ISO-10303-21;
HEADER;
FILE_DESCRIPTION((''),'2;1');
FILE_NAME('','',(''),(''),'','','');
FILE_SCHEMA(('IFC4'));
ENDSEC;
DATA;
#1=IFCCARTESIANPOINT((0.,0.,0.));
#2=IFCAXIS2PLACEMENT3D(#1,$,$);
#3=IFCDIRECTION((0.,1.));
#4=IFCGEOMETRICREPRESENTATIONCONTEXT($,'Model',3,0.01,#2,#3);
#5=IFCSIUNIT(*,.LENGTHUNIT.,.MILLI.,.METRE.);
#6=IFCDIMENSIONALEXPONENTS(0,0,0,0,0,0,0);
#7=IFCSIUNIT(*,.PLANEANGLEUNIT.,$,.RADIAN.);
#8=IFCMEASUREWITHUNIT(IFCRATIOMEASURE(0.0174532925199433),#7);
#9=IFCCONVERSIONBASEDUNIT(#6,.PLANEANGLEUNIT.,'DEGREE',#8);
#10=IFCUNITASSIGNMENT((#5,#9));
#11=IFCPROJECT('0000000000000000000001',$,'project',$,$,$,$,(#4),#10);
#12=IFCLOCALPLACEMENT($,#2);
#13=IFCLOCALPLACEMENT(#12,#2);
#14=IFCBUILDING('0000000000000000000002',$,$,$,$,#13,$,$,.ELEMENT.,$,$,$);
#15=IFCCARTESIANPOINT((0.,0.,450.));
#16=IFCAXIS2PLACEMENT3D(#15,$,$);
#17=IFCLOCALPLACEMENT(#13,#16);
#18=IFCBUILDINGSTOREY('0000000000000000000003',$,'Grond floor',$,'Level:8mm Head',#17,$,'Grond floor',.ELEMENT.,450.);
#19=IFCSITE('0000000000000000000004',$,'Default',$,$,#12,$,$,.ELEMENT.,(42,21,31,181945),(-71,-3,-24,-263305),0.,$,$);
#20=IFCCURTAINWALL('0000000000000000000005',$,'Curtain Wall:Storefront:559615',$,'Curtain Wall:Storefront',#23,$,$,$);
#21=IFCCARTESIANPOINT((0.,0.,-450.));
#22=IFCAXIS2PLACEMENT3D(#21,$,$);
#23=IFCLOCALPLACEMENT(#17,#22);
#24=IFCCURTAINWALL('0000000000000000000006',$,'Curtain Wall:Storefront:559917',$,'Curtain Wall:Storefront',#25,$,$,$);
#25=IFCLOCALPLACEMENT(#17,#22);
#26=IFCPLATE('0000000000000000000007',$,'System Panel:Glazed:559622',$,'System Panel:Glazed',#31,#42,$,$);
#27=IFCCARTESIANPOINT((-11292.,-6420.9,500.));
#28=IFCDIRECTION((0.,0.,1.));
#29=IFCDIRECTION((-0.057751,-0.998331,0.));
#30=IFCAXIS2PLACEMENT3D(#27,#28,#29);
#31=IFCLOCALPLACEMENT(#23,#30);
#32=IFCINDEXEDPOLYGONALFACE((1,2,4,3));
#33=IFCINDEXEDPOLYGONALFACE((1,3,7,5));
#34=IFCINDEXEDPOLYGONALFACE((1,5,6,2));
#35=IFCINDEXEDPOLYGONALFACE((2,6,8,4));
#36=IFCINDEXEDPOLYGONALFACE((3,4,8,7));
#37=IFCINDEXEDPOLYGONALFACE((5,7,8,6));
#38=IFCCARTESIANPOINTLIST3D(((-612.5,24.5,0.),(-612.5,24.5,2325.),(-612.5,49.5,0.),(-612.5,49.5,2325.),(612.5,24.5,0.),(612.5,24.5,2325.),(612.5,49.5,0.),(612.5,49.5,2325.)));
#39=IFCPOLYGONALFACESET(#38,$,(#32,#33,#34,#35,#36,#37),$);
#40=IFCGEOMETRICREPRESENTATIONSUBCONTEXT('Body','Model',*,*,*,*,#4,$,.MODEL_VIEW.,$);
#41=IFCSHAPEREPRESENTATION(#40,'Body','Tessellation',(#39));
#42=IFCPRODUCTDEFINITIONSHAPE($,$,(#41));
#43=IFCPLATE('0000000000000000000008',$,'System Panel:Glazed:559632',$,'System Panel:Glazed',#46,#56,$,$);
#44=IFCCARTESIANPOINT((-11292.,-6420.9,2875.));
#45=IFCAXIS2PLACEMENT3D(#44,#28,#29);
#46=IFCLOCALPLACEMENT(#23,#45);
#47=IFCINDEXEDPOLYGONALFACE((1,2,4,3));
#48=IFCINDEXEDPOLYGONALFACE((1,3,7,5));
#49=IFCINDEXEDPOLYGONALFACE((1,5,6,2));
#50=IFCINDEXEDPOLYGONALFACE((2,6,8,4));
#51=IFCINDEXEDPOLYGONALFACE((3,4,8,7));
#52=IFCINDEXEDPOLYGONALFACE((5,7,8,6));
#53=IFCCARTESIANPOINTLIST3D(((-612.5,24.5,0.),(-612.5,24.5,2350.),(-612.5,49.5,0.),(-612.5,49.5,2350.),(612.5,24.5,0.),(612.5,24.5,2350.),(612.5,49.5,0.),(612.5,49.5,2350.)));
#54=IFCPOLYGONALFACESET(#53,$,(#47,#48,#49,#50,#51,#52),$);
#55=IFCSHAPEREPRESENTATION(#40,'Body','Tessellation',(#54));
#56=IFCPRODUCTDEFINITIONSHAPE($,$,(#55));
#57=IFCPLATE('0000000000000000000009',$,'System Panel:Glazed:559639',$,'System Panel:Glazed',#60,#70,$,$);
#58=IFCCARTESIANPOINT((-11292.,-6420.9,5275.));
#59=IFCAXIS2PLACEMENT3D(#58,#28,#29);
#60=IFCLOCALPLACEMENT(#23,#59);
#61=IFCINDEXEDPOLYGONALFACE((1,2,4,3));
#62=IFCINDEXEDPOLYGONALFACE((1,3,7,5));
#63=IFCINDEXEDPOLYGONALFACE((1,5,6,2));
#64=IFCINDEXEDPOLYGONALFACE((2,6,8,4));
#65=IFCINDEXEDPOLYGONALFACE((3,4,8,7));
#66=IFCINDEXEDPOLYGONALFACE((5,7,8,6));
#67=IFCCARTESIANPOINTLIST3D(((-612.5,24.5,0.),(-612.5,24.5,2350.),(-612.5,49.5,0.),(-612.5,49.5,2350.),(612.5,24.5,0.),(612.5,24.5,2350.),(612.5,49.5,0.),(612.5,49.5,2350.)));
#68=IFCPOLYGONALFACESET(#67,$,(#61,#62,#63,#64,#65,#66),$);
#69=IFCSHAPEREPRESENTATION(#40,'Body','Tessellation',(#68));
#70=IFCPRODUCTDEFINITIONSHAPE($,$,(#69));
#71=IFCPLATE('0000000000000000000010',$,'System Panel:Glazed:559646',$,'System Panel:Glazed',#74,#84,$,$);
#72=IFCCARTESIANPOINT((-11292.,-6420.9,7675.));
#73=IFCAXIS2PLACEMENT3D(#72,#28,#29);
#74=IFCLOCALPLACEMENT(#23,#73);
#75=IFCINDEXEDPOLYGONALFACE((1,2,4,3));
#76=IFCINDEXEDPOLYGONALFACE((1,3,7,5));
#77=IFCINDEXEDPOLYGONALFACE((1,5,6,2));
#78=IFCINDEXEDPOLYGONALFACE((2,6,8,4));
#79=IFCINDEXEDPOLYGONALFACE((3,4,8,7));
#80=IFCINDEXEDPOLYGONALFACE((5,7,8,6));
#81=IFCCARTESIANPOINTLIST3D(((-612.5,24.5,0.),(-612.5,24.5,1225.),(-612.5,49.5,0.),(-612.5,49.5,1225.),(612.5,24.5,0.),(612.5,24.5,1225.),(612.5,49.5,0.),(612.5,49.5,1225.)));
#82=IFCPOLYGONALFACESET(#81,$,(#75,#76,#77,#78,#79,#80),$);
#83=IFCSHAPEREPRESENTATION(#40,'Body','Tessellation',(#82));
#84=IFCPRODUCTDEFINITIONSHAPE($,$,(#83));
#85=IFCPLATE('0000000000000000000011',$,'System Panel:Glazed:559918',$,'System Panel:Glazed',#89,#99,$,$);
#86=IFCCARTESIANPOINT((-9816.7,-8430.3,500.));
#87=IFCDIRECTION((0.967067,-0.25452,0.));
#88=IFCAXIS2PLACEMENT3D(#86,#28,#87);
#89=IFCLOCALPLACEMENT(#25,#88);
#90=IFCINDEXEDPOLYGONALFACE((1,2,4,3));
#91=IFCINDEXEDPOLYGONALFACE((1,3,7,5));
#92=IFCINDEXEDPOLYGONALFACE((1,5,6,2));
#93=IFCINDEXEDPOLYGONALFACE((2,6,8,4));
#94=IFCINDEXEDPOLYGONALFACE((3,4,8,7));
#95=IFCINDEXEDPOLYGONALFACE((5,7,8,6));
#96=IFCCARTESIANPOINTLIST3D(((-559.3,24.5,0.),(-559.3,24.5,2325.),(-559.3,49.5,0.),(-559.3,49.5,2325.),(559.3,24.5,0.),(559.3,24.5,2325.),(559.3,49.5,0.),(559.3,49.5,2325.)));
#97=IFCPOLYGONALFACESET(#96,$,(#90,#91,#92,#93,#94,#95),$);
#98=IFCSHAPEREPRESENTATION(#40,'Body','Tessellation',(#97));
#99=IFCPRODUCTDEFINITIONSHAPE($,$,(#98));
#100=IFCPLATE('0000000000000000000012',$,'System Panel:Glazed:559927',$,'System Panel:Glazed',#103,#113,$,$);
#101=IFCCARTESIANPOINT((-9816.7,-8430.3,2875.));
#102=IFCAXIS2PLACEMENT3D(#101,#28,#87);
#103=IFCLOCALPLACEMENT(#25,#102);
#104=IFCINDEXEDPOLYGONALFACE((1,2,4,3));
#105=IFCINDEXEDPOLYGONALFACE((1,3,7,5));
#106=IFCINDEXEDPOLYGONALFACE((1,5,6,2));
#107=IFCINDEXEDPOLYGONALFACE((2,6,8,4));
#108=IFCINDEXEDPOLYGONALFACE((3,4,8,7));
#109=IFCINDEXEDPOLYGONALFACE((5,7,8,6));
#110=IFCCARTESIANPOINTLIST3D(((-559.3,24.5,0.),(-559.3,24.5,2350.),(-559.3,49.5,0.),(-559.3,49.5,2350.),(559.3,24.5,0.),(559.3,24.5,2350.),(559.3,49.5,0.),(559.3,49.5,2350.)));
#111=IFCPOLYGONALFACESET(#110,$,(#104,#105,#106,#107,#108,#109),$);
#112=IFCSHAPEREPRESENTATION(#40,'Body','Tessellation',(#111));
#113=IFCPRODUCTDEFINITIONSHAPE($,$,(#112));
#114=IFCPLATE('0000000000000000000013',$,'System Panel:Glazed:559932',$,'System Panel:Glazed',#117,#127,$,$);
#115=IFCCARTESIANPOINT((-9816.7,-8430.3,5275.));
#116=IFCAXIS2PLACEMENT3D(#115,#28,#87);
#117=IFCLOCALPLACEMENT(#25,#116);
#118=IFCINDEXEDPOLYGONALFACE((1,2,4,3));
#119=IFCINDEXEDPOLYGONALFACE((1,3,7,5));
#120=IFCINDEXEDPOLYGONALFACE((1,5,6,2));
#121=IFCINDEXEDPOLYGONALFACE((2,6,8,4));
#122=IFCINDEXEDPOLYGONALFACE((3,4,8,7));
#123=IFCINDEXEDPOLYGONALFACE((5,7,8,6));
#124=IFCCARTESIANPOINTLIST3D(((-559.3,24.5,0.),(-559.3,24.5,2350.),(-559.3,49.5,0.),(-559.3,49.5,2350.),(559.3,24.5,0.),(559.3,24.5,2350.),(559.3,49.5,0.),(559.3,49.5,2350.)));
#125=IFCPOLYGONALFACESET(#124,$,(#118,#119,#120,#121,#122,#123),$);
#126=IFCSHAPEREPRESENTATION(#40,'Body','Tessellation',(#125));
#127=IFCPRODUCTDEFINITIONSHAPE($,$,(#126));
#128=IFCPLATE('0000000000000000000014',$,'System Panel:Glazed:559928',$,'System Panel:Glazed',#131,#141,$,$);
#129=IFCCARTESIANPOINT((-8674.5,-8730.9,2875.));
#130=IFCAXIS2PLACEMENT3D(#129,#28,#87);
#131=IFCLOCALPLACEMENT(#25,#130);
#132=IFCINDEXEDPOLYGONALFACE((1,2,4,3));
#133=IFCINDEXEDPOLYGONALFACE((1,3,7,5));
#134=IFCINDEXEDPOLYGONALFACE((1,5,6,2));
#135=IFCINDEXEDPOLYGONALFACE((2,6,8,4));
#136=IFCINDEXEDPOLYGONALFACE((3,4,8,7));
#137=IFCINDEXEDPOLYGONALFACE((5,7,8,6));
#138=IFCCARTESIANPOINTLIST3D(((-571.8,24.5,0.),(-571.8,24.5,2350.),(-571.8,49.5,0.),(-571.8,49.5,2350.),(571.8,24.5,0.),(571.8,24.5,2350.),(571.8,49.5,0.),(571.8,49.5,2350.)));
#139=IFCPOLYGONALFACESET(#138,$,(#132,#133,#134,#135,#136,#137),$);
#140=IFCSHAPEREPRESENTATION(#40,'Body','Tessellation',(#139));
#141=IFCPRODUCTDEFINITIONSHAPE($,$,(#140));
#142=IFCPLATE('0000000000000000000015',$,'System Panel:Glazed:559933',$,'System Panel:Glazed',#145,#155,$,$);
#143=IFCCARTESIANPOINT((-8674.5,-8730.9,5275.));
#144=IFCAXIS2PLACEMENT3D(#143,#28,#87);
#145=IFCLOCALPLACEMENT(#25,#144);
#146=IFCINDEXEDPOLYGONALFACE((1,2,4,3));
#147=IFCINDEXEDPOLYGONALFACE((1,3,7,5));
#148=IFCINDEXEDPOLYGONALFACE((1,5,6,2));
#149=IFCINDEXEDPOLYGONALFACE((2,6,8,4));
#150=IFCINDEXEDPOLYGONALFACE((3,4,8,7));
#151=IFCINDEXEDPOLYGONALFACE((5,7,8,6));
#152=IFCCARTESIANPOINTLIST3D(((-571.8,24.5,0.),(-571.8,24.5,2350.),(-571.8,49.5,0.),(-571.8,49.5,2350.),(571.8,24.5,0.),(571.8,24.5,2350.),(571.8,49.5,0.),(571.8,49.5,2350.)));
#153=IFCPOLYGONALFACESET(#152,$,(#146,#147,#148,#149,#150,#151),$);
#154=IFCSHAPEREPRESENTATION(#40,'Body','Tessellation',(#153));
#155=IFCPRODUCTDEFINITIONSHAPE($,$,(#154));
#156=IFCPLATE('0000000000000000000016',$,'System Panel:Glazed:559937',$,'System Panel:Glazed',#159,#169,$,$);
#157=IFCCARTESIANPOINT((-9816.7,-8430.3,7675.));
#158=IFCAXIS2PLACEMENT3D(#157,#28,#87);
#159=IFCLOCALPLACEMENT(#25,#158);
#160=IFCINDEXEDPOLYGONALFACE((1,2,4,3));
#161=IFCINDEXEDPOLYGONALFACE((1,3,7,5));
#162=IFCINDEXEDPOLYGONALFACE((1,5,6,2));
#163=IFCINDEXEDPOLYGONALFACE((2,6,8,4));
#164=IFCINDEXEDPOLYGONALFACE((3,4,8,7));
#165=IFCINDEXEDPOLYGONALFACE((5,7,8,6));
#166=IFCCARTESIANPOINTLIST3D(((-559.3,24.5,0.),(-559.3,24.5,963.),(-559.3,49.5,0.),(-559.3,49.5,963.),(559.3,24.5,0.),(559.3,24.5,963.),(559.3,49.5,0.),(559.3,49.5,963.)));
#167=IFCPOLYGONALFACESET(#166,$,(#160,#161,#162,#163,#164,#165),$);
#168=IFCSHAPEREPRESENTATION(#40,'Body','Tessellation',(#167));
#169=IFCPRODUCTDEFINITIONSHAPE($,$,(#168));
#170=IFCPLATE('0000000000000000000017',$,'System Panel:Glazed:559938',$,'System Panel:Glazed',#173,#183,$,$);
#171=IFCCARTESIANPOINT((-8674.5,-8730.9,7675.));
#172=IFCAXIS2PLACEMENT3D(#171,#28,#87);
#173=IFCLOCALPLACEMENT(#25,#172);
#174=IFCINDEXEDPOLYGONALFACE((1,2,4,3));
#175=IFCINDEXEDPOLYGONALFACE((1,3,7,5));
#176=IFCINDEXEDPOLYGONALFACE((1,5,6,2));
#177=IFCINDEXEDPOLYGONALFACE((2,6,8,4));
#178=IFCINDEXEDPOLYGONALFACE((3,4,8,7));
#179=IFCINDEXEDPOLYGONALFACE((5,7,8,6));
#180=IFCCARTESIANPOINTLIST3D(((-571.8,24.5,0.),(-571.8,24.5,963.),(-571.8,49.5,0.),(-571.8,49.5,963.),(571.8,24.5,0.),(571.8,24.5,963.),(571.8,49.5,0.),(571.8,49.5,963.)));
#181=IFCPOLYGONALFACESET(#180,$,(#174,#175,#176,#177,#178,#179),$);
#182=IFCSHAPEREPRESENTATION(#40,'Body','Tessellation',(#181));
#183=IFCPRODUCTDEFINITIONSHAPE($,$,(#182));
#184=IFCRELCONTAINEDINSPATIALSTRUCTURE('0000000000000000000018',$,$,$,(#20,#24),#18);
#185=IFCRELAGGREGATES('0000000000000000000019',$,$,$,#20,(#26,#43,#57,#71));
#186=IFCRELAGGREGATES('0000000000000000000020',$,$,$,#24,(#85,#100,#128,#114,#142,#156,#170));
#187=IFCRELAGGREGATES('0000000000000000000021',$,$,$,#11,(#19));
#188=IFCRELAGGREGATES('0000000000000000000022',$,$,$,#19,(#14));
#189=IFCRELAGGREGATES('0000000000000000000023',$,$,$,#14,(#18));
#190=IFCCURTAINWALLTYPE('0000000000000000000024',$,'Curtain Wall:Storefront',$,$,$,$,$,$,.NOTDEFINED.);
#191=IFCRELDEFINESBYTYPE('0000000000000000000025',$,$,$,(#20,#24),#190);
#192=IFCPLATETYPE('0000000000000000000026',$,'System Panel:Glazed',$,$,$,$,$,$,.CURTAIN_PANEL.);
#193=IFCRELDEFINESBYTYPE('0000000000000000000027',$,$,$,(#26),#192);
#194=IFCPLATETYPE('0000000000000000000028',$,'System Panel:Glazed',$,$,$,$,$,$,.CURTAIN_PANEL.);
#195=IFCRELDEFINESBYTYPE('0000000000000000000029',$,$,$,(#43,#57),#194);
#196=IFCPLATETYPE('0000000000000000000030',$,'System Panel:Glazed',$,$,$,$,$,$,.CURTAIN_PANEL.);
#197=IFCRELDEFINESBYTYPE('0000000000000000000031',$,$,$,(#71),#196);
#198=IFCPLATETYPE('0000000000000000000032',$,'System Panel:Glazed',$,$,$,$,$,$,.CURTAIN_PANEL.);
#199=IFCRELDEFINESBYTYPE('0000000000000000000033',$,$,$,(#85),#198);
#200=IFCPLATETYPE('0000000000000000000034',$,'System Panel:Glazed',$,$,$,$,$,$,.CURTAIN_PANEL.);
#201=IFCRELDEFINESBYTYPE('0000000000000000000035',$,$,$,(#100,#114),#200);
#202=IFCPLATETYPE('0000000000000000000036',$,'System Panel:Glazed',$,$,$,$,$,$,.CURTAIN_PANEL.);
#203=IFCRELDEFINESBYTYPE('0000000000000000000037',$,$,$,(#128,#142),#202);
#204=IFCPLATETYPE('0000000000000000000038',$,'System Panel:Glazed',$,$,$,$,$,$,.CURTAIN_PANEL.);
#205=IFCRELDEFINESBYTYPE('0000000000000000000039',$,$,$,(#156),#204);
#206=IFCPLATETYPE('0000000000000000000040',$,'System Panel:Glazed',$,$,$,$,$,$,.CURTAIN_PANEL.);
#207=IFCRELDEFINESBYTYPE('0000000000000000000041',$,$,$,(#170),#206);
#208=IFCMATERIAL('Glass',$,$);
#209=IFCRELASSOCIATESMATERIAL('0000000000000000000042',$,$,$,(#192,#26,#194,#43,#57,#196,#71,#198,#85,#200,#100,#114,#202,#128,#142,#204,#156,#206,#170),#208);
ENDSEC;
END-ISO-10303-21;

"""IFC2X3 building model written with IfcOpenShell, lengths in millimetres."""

from ifc_helpers import new_model, entity, si_unit, converted_unit, direction, frame, frame_2d, origin, place, context, subcontext, project, spatial, rectangle, extrude, source, transform, mapped, material, type_object, type_shapes, element, aggregate, save


model = new_model("IFC2X3")

# Units and contexts
model_context = context("Model", 3, precision=0.01, world=origin(), true_north=direction((0.0, 1.0)))
body_context = subcontext(model_context, "Body", "Model", "MODEL_VIEW")
ifc_project = project(units=[si_unit("LENGTHUNIT", "METRE", prefix="MILLI"), converted_unit("PLANEANGLEUNIT", "DEGREE", entity("IfcRatioMeasure", 0.0174532925199433), si_unit("PLANEANGLEUNIT", "RADIAN"), dimensions=[0, 0, 0, 0, 0, 0, 0])], contexts=[model_context])

# Site, building, storey
site_placement = place(None, origin())
site = spatial("IfcSite", under=ifc_project, at=site_placement, Name="Default", CompositionType="ELEMENT", RefLatitude=(42, 21, 31, 181945), RefLongitude=(-71, -3, -24, -263305), RefElevation=0.0)
building_placement = place(site_placement, origin())
building = spatial("IfcBuilding", under=site, at=building_placement, CompositionType="ELEMENT")
storey_placement = place(building_placement, frame((0.0, 0.0, 450.0)))
storey = spatial("IfcBuildingStorey", under=building, at=storey_placement, Name="Grond floor", ObjectType="Level:8mm Head", LongName="Grond floor", CompositionType="ELEMENT", Elevation=450.0)

# Curtain walls
curtain_wall_type = type_object("IfcCurtainWallType", Name="Curtain Wall:Storefront", PredefinedType="NOTDEFINED")
curtain_wall_1_placement = place(storey_placement, frame((0.0, 0.0, -450.0)))
curtain_wall_1 = element("IfcCurtainWall", 1, at=curtain_wall_1_placement, inside=storey, type_object=curtain_wall_type, Name="Curtain Wall:Storefront:559615", ObjectType="Curtain Wall:Storefront")
curtain_wall_2_placement = place(storey_placement, frame((0.0, 0.0, -450.0)))
curtain_wall_2 = element("IfcCurtainWall", 2, at=curtain_wall_2_placement, inside=storey, type_object=curtain_wall_type, Name="Curtain Wall:Storefront:559917", ObjectType="Curtain Wall:Storefront")

# Plates
ifc_material_1 = material(Name="Glass")
plate_type_1 = type_object("IfcPlateType", Name="System Panel:Glazed", PredefinedType="CURTAIN_PANEL", material=ifc_material_1)
shared_shape_1 = source(origin(), body_context, "Body", "SweptSolid", [
    extrude(rectangle(XDim=25.0, YDim=1225.0, at=frame_2d((0.0, 0.0), x_axis=(1.0, 0.0))), frame((0.0, 37.0, 0.0), z_axis=(0.0, 0.0, 1.0), x_axis=(0.0, 1.0, 0.0)), (0.0, 0.0, 1.0), 2325.0),
])
type_shapes(plate_type_1, [shared_shape_1])
plate_1_placement = place(curtain_wall_1_placement, frame((-11292.0, -6420.9, 500.0), z_axis=(0.0, 0.0, 1.0), x_axis=(-0.057751, -0.998331, 0.0)))
plate_1 = element("IfcPlate", 3, at=plate_1_placement, type_object=plate_type_1, material=ifc_material_1, Name="System Panel:Glazed:559622", ObjectType="System Panel:Glazed", context=body_context, shape_type="MappedRepresentation", body=[
    mapped(shared_shape_1, transform((0.0, 0.0, 0.0), scale=1.0)),
])
plate_type_2 = type_object("IfcPlateType", Name="System Panel:Glazed", PredefinedType="CURTAIN_PANEL", material=ifc_material_1)
shared_shape_2 = source(origin(), body_context, "Body", "SweptSolid", [
    extrude(rectangle(XDim=25.0, YDim=1225.0, at=frame_2d((0.0, 0.0), x_axis=(1.0, 0.0))), frame((0.0, 37.0, 0.0), z_axis=(0.0, 0.0, 1.0), x_axis=(0.0, 1.0, 0.0)), (0.0, 0.0, 1.0), 2350.0),
])
type_shapes(plate_type_2, [shared_shape_2])
plate_2_placement = place(curtain_wall_1_placement, frame((-11292.0, -6420.9, 2875.0), z_axis=(0.0, 0.0, 1.0), x_axis=(-0.057751, -0.998331, 0.0)))
plate_2 = element("IfcPlate", 4, at=plate_2_placement, type_object=plate_type_2, material=ifc_material_1, Name="System Panel:Glazed:559632", ObjectType="System Panel:Glazed", context=body_context, shape_type="MappedRepresentation", body=[
    mapped(shared_shape_2, transform((0.0, 0.0, 0.0), scale=1.0)),
])
plate_3_placement = place(curtain_wall_1_placement, frame((-11292.0, -6420.9, 5275.0), z_axis=(0.0, 0.0, 1.0), x_axis=(-0.057751, -0.998331, 0.0)))
plate_3 = element("IfcPlate", 5, at=plate_3_placement, type_object=plate_type_2, material=ifc_material_1, Name="System Panel:Glazed:559639", ObjectType="System Panel:Glazed", context=body_context, shape_type="MappedRepresentation", body=[
    mapped(shared_shape_2, transform((0.0, 0.0, 0.0), scale=1.0)),
])
plate_type_3 = type_object("IfcPlateType", Name="System Panel:Glazed", PredefinedType="CURTAIN_PANEL", material=ifc_material_1)
shared_shape_3 = source(origin(), body_context, "Body", "SweptSolid", [
    extrude(rectangle(XDim=25.0, YDim=1225.0, at=frame_2d((0.0, 0.0), x_axis=(1.0, 0.0))), frame((0.0, 37.0, 0.0), z_axis=(0.0, 0.0, 1.0), x_axis=(0.0, 1.0, 0.0)), (0.0, 0.0, 1.0), 1225.0),
])
type_shapes(plate_type_3, [shared_shape_3])
plate_4_placement = place(curtain_wall_1_placement, frame((-11292.0, -6420.9, 7675.0), z_axis=(0.0, 0.0, 1.0), x_axis=(-0.057751, -0.998331, 0.0)))
plate_4 = element("IfcPlate", 6, at=plate_4_placement, type_object=plate_type_3, material=ifc_material_1, Name="System Panel:Glazed:559646", ObjectType="System Panel:Glazed", context=body_context, shape_type="MappedRepresentation", body=[
    mapped(shared_shape_3, transform((0.0, 0.0, 0.0), scale=1.0)),
])
aggregate(curtain_wall_1, [plate_1, plate_2, plate_3, plate_4])
plate_type_4 = type_object("IfcPlateType", Name="System Panel:Glazed", PredefinedType="CURTAIN_PANEL", material=ifc_material_1)
shared_shape_4 = source(origin(), body_context, "Body", "SweptSolid", [
    extrude(rectangle(XDim=25.0, YDim=1118.6, at=frame_2d((0.0, 0.0), x_axis=(1.0, 0.0))), frame((0.0, 37.0, 0.0), z_axis=(0.0, 0.0, 1.0), x_axis=(0.0, 1.0, 0.0)), (0.0, 0.0, 1.0), 2325.0),
])
type_shapes(plate_type_4, [shared_shape_4])
plate_5_placement = place(curtain_wall_2_placement, frame((-9816.7, -8430.3, 500.0), z_axis=(0.0, 0.0, 1.0), x_axis=(0.967067, -0.25452, 0.0)))
plate_5 = element("IfcPlate", 7, at=plate_5_placement, type_object=plate_type_4, material=ifc_material_1, Name="System Panel:Glazed:559918", ObjectType="System Panel:Glazed", context=body_context, shape_type="MappedRepresentation", body=[
    mapped(shared_shape_4, transform((0.0, 0.0, 0.0), scale=1.0)),
])
plate_type_5 = type_object("IfcPlateType", Name="System Panel:Glazed", PredefinedType="CURTAIN_PANEL", material=ifc_material_1)
shared_shape_5 = source(origin(), body_context, "Body", "SweptSolid", [
    extrude(rectangle(XDim=25.0, YDim=1118.6, at=frame_2d((0.0, 0.0), x_axis=(1.0, 0.0))), frame((0.0, 37.0, 0.0), z_axis=(0.0, 0.0, 1.0), x_axis=(0.0, 1.0, 0.0)), (0.0, 0.0, 1.0), 2350.0),
])
type_shapes(plate_type_5, [shared_shape_5])
plate_6_placement = place(curtain_wall_2_placement, frame((-9816.7, -8430.3, 2875.0), z_axis=(0.0, 0.0, 1.0), x_axis=(0.967067, -0.25452, 0.0)))
plate_6 = element("IfcPlate", 8, at=plate_6_placement, type_object=plate_type_5, material=ifc_material_1, Name="System Panel:Glazed:559927", ObjectType="System Panel:Glazed", context=body_context, shape_type="MappedRepresentation", body=[
    mapped(shared_shape_5, transform((0.0, 0.0, 0.0), scale=1.0)),
])
plate_7_placement = place(curtain_wall_2_placement, frame((-9816.7, -8430.3, 5275.0), z_axis=(0.0, 0.0, 1.0), x_axis=(0.967067, -0.25452, 0.0)))
plate_7 = element("IfcPlate", 9, at=plate_7_placement, type_object=plate_type_5, material=ifc_material_1, Name="System Panel:Glazed:559932", ObjectType="System Panel:Glazed", context=body_context, shape_type="MappedRepresentation", body=[
    mapped(shared_shape_5, transform((0.0, 0.0, 0.0), scale=1.0)),
])
plate_type_6 = type_object("IfcPlateType", Name="System Panel:Glazed", PredefinedType="CURTAIN_PANEL", material=ifc_material_1)
shared_shape_6 = source(origin(), body_context, "Body", "SweptSolid", [
    extrude(rectangle(XDim=25.0, YDim=1143.6, at=frame_2d((0.0, 0.0), x_axis=(1.0, 0.0))), frame((0.0, 37.0, 0.0), z_axis=(0.0, 0.0, 1.0), x_axis=(0.0, 1.0, 0.0)), (0.0, 0.0, 1.0), 2350.0),
])
type_shapes(plate_type_6, [shared_shape_6])
plate_8_placement = place(curtain_wall_2_placement, frame((-8674.5, -8730.9, 2875.0), z_axis=(0.0, 0.0, 1.0), x_axis=(0.967067, -0.25452, 0.0)))
plate_8 = element("IfcPlate", 10, at=plate_8_placement, type_object=plate_type_6, material=ifc_material_1, Name="System Panel:Glazed:559928", ObjectType="System Panel:Glazed", context=body_context, shape_type="MappedRepresentation", body=[
    mapped(shared_shape_6, transform((0.0, 0.0, 0.0), scale=1.0)),
])
plate_9_placement = place(curtain_wall_2_placement, frame((-8674.5, -8730.9, 5275.0), z_axis=(0.0, 0.0, 1.0), x_axis=(0.967067, -0.25452, 0.0)))
plate_9 = element("IfcPlate", 11, at=plate_9_placement, type_object=plate_type_6, material=ifc_material_1, Name="System Panel:Glazed:559933", ObjectType="System Panel:Glazed", context=body_context, shape_type="MappedRepresentation", body=[
    mapped(shared_shape_6, transform((0.0, 0.0, 0.0), scale=1.0)),
])
plate_type_7 = type_object("IfcPlateType", Name="System Panel:Glazed", PredefinedType="CURTAIN_PANEL", material=ifc_material_1)
shared_shape_7 = source(origin(), body_context, "Body", "SweptSolid", [
    extrude(rectangle(XDim=25.0, YDim=1118.6, at=frame_2d((0.0, 0.0), x_axis=(1.0, 0.0))), frame((0.0, 37.0, 0.0), z_axis=(0.0, 0.0, 1.0), x_axis=(0.0, 1.0, 0.0)), (0.0, 0.0, 1.0), 963.0),
])
type_shapes(plate_type_7, [shared_shape_7])
plate_10_placement = place(curtain_wall_2_placement, frame((-9816.7, -8430.3, 7675.0), z_axis=(0.0, 0.0, 1.0), x_axis=(0.967067, -0.25452, 0.0)))
plate_10 = element("IfcPlate", 12, at=plate_10_placement, type_object=plate_type_7, material=ifc_material_1, Name="System Panel:Glazed:559937", ObjectType="System Panel:Glazed", context=body_context, shape_type="MappedRepresentation", body=[
    mapped(shared_shape_7, transform((0.0, 0.0, 0.0), scale=1.0)),
])
plate_type_8 = type_object("IfcPlateType", Name="System Panel:Glazed", PredefinedType="CURTAIN_PANEL", material=ifc_material_1)
shared_shape_8 = source(origin(), body_context, "Body", "SweptSolid", [
    extrude(rectangle(XDim=25.0, YDim=1143.6, at=frame_2d((0.0, 0.0), x_axis=(1.0, 0.0))), frame((0.0, 37.0, 0.0), z_axis=(0.0, 0.0, 1.0), x_axis=(0.0, 1.0, 0.0)), (0.0, 0.0, 1.0), 963.0),
])
type_shapes(plate_type_8, [shared_shape_8])
plate_11_placement = place(curtain_wall_2_placement, frame((-8674.5, -8730.9, 7675.0), z_axis=(0.0, 0.0, 1.0), x_axis=(0.967067, -0.25452, 0.0)))
plate_11 = element("IfcPlate", 13, at=plate_11_placement, type_object=plate_type_8, material=ifc_material_1, Name="System Panel:Glazed:559938", ObjectType="System Panel:Glazed", context=body_context, shape_type="MappedRepresentation", body=[
    mapped(shared_shape_8, transform((0.0, 0.0, 0.0), scale=1.0)),
])
aggregate(curtain_wall_2, [plate_5, plate_6, plate_8, plate_7, plate_9, plate_10, plate_11])

save(model, "model.ifc")
